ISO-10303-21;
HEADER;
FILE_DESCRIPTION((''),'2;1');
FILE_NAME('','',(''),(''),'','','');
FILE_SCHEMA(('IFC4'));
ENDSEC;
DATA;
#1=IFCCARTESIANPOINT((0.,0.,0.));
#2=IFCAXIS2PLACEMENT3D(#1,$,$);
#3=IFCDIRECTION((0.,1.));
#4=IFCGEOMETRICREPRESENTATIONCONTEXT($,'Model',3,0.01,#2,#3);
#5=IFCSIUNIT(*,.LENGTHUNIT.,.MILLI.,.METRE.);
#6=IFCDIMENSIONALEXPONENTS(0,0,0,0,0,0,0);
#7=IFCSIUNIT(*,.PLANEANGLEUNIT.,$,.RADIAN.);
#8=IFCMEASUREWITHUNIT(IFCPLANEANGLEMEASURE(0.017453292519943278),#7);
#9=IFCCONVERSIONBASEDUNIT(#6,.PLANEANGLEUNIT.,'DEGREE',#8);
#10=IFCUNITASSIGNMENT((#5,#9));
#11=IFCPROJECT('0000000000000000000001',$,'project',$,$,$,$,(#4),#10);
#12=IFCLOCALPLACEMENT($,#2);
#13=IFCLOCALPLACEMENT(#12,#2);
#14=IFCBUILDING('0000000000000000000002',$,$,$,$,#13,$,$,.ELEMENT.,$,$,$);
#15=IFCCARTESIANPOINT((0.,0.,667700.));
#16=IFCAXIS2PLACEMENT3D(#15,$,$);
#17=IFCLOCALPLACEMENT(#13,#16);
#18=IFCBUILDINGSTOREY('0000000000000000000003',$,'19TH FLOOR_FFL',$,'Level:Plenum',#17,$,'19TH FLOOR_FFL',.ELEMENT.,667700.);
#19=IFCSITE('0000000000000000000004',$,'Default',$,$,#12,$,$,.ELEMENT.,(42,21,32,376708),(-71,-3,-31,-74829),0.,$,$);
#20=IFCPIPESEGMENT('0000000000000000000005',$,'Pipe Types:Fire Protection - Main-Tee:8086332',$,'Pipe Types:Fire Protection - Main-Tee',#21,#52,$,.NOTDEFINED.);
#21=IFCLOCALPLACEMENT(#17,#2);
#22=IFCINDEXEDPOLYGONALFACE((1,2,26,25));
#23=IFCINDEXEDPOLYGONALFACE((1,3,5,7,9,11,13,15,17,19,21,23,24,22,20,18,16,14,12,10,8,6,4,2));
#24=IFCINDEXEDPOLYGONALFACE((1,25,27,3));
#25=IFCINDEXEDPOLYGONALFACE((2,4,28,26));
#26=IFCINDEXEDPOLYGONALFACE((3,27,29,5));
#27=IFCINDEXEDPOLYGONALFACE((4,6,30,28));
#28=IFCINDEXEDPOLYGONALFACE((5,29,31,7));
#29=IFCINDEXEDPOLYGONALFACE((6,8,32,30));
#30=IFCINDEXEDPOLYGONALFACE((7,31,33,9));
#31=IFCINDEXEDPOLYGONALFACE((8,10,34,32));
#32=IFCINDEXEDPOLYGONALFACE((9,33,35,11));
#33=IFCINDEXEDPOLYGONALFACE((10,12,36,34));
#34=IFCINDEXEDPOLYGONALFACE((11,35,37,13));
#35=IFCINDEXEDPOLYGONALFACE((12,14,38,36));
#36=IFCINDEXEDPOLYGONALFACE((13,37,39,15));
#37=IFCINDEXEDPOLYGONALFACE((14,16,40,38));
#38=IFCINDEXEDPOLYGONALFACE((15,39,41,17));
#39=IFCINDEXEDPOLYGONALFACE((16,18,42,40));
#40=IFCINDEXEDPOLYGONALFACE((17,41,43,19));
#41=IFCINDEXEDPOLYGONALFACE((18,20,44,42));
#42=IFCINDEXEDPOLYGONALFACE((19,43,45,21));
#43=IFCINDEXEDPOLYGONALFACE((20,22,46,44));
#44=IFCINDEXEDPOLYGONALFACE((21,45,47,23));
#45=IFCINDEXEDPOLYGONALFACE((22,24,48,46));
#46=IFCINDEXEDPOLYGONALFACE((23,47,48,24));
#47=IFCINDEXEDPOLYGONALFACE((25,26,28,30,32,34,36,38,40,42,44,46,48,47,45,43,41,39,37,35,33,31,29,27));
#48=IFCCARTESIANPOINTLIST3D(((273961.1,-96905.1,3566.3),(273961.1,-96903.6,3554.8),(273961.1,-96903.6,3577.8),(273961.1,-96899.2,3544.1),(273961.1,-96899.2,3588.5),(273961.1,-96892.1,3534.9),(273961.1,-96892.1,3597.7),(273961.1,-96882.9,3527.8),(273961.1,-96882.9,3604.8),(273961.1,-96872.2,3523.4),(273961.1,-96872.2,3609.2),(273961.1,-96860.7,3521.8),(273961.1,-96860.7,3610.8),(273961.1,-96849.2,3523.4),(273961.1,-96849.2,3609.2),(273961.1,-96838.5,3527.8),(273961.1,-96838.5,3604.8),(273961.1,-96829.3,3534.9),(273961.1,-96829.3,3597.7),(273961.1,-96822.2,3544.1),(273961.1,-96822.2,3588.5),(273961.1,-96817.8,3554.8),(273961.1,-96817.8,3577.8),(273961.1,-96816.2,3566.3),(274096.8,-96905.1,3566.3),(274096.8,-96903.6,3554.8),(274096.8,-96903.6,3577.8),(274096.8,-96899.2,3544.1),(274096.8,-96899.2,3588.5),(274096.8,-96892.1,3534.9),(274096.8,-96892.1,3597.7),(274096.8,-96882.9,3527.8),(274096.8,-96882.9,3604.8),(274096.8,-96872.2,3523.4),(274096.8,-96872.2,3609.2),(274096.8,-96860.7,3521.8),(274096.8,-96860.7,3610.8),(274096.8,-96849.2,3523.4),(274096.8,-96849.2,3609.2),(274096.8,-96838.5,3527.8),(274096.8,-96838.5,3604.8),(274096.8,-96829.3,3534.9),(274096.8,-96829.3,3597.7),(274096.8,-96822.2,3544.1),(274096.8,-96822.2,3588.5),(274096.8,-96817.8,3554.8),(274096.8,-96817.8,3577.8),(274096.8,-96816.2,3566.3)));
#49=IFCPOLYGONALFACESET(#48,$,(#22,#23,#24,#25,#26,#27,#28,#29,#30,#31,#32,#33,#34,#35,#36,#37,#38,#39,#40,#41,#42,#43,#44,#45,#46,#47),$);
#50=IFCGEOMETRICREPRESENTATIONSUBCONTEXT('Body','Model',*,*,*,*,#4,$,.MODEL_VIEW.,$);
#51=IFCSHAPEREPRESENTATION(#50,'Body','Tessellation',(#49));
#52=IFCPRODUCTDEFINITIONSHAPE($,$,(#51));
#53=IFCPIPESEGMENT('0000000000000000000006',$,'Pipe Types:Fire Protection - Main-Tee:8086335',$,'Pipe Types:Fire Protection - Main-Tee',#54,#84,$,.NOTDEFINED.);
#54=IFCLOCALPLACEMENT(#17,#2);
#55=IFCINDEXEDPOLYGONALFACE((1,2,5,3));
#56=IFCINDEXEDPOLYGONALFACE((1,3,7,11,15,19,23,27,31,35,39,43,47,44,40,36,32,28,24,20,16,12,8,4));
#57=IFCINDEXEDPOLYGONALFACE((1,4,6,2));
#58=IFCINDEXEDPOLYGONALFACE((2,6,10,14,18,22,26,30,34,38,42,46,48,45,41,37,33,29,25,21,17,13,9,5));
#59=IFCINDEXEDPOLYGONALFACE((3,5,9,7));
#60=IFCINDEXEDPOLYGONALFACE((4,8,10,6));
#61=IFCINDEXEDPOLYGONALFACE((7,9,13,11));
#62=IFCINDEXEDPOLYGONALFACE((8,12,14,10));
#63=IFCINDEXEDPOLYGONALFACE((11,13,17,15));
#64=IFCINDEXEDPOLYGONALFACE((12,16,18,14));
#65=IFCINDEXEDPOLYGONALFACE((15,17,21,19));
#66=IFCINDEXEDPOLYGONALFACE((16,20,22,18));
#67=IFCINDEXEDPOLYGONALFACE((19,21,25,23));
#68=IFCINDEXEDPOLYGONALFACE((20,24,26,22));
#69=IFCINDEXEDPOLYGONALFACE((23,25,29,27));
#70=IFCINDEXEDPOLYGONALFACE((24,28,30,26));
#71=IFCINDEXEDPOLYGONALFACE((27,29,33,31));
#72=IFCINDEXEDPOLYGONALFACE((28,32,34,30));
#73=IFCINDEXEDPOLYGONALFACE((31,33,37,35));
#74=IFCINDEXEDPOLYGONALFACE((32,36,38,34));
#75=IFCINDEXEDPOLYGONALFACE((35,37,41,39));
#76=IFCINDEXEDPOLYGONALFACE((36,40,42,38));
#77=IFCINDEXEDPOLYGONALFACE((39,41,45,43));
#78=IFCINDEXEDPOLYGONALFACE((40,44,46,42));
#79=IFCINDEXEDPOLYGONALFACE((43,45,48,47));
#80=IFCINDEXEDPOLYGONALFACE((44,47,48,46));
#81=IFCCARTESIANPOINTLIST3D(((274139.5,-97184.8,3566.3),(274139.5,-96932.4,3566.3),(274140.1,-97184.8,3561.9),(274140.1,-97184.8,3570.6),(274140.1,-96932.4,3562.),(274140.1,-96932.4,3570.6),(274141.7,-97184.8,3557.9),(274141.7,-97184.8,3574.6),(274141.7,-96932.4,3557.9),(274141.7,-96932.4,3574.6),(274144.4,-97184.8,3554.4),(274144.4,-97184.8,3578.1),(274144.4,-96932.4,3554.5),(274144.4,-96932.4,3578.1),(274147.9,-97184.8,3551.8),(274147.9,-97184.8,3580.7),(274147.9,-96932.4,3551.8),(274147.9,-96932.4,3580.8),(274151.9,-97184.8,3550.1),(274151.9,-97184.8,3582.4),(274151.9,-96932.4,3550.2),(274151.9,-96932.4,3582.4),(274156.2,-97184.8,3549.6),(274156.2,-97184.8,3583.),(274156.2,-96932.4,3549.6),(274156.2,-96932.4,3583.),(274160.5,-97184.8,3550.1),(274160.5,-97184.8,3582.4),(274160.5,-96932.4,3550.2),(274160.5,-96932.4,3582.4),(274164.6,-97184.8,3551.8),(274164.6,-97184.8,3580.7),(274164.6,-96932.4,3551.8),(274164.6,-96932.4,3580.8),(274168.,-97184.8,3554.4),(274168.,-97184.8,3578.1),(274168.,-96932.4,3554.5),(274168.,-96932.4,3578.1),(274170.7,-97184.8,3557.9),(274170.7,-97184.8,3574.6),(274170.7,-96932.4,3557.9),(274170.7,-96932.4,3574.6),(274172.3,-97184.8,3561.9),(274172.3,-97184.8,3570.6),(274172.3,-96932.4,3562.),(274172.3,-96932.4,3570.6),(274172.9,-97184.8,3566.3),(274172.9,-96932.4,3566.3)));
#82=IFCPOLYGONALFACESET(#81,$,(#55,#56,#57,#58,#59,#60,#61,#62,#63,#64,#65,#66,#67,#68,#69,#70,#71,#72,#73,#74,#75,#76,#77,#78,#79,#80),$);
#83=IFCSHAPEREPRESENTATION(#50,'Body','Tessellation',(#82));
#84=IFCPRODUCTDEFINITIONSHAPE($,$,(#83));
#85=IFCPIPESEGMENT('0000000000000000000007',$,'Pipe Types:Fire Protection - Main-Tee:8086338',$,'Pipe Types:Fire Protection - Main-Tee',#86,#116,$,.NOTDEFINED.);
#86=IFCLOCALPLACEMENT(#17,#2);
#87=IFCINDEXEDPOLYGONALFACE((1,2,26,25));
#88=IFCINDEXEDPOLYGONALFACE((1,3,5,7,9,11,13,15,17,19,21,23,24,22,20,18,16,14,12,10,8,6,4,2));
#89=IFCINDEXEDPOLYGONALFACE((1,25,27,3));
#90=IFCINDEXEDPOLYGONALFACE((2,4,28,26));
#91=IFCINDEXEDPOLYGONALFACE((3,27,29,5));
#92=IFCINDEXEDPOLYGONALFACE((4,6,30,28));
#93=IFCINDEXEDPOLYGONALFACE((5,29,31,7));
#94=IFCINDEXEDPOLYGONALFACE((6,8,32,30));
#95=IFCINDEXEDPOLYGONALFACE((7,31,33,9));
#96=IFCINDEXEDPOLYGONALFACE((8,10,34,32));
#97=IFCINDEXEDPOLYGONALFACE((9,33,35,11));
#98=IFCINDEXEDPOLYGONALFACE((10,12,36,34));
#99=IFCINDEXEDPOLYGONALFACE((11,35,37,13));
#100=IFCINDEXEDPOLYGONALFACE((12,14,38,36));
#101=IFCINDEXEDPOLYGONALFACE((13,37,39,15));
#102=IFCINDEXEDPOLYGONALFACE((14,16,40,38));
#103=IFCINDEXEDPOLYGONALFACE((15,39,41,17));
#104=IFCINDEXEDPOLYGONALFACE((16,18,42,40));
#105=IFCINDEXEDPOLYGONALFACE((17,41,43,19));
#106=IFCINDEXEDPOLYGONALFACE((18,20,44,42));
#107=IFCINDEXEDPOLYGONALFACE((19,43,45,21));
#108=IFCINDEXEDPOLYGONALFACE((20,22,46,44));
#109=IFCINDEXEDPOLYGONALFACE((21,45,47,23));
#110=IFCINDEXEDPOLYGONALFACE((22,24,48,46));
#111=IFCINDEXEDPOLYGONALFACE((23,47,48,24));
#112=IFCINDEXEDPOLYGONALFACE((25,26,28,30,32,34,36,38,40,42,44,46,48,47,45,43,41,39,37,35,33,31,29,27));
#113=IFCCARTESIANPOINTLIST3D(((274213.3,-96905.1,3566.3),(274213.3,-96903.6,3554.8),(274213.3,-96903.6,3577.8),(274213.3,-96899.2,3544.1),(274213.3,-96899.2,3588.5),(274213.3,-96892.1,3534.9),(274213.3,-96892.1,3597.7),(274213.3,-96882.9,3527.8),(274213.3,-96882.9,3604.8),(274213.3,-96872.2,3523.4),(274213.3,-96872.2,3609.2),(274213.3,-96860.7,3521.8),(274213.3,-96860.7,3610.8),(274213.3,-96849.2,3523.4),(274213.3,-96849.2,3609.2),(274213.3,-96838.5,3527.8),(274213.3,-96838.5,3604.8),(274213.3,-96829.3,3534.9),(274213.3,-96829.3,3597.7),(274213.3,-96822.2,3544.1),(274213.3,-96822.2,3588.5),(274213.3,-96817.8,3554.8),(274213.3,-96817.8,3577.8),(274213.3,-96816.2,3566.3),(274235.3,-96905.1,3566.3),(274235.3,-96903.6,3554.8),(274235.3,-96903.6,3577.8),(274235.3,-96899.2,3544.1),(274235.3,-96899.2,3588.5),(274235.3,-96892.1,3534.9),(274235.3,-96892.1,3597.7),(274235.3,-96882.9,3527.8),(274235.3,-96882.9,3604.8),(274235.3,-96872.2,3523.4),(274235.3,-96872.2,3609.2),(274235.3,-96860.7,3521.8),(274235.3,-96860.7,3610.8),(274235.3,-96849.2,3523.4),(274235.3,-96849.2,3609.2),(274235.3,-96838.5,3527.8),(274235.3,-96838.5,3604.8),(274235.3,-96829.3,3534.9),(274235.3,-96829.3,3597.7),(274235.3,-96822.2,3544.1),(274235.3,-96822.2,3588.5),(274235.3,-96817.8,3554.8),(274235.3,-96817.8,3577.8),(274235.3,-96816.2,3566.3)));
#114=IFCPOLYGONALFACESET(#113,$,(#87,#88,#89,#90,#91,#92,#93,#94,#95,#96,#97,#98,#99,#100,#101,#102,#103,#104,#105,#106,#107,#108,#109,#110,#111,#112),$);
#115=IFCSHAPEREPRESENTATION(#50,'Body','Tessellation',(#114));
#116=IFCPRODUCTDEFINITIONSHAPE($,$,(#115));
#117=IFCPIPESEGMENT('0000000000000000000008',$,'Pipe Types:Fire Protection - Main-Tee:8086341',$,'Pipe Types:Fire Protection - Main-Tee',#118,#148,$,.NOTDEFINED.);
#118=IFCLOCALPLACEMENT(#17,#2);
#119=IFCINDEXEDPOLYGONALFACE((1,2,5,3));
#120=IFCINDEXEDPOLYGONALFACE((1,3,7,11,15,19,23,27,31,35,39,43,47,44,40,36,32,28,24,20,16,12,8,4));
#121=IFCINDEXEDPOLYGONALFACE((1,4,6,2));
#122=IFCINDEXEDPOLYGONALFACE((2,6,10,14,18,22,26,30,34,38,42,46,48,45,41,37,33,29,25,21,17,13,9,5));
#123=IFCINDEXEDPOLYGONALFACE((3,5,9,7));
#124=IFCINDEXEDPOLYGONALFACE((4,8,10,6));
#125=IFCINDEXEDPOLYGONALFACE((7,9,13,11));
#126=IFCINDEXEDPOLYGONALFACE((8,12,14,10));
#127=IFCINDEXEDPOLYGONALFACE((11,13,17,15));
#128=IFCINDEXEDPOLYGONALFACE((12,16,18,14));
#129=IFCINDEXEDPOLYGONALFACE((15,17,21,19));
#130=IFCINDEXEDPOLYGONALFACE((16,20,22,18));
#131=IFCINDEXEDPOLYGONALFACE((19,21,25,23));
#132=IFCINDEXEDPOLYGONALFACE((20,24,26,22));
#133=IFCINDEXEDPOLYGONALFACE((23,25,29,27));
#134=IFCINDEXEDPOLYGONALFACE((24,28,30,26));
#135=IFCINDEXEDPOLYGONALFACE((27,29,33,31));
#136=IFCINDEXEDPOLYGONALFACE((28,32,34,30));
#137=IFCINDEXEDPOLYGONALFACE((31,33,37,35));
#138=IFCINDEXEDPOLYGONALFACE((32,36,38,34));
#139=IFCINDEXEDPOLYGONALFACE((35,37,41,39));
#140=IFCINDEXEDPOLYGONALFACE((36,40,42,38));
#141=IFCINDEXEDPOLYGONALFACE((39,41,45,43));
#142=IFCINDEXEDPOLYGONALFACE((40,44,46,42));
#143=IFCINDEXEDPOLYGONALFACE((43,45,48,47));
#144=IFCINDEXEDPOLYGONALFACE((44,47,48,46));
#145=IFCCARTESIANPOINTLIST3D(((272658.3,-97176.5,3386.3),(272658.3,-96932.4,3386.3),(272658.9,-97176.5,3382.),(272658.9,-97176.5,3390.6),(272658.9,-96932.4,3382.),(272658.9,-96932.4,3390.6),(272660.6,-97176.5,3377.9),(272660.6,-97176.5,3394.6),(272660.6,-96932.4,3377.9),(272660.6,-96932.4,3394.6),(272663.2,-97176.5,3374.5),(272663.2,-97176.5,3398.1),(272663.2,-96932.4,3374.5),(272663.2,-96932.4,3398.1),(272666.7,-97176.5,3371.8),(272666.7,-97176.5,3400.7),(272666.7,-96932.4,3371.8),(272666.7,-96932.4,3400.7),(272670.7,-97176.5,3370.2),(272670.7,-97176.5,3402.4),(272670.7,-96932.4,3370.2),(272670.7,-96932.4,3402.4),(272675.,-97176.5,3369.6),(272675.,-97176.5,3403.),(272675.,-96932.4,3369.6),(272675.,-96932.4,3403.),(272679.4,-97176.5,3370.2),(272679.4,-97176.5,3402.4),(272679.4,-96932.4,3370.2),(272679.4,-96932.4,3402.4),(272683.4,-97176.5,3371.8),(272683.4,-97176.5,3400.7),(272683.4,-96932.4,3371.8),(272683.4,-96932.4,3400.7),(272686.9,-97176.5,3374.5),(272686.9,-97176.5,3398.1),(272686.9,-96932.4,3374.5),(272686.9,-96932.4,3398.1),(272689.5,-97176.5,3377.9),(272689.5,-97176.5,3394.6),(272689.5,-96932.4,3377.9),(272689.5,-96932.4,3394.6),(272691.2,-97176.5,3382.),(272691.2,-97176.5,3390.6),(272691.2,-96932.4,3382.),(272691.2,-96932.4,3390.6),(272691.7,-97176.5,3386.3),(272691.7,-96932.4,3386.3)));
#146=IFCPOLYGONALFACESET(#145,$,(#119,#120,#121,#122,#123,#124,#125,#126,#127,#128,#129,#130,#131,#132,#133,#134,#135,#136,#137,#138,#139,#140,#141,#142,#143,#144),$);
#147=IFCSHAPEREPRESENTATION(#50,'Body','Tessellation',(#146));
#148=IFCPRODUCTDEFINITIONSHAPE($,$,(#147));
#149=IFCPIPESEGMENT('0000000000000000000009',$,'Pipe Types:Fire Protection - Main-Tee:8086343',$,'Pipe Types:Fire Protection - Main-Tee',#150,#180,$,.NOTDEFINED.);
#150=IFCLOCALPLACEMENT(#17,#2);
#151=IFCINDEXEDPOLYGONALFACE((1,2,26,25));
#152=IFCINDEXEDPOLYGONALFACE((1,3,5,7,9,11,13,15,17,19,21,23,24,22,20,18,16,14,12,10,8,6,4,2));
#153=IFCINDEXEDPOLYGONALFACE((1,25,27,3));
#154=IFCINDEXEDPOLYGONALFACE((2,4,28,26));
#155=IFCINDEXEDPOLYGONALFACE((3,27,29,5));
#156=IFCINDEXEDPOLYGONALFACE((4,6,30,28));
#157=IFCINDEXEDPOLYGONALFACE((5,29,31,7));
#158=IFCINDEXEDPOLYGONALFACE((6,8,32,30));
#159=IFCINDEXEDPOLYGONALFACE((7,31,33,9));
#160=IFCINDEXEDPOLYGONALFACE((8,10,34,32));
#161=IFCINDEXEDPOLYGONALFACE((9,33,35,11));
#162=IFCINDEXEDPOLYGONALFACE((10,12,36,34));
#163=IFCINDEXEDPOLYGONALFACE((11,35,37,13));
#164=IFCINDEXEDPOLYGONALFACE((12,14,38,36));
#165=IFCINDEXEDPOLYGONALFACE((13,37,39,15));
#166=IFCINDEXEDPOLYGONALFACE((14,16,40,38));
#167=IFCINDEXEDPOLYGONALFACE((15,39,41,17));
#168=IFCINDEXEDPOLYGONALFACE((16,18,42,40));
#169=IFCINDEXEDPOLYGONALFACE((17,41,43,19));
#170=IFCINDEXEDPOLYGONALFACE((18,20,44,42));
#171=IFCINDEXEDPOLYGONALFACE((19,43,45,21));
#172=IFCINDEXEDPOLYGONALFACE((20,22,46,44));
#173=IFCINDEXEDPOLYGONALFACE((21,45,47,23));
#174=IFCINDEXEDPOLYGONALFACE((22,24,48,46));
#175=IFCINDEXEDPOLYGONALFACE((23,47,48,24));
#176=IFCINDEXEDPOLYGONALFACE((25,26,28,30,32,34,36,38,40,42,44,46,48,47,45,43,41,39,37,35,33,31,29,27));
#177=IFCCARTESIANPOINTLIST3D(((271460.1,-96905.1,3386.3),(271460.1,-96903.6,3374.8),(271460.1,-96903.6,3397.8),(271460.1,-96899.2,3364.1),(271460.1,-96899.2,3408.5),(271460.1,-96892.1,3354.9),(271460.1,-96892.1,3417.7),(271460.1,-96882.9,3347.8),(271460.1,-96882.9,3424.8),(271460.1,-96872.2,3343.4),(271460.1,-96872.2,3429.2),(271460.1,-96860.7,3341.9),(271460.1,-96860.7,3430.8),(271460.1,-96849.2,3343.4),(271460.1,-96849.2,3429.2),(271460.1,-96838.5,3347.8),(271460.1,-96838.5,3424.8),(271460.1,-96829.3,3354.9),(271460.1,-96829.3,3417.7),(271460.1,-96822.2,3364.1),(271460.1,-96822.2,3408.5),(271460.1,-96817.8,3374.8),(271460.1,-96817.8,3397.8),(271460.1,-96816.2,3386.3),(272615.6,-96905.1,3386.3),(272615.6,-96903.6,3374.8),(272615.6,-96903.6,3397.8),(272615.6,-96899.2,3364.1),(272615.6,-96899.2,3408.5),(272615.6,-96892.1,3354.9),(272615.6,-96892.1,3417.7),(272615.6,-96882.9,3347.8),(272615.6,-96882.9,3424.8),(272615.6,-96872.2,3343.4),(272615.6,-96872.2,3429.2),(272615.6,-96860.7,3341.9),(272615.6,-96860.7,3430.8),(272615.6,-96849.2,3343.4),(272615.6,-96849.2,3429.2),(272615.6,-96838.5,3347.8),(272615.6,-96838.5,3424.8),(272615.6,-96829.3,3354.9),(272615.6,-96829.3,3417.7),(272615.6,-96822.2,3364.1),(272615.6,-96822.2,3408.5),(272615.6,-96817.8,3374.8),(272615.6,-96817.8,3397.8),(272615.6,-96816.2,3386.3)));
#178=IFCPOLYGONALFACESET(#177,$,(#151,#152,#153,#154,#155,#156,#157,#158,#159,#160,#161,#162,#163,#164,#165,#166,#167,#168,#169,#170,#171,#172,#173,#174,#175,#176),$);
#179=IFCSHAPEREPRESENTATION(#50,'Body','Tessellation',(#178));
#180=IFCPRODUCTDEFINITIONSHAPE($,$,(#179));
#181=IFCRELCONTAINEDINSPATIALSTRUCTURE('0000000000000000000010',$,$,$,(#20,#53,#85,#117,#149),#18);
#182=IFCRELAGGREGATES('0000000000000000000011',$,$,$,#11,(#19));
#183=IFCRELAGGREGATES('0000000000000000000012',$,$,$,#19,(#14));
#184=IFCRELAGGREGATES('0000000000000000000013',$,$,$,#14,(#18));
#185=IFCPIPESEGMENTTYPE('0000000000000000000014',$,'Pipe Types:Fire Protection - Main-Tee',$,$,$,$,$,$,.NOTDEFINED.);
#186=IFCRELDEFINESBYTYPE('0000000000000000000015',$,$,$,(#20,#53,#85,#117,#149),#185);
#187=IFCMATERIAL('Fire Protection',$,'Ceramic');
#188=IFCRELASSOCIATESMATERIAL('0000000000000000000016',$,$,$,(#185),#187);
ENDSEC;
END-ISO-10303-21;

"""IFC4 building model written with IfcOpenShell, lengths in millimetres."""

from ifc_helpers import new_model, entity, si_unit, converted_unit, direction, frame, origin, place, context, subcontext, project, spatial, arc, indexed_curve, outline, extrude, material, type_object, element, save


model = new_model("IFC4")

# Units and contexts
model_context = context("Model", 3, precision=0.01, world=origin(), true_north=direction((0.0, 1.0)))
body_context = subcontext(model_context, "Body", "Model", "MODEL_VIEW")
ifc_project = project(units=[si_unit("LENGTHUNIT", "METRE", prefix="MILLI"), converted_unit("PLANEANGLEUNIT", "DEGREE", entity("IfcPlaneAngleMeasure", 0.017453292519943278), si_unit("PLANEANGLEUNIT", "RADIAN"), dimensions=[0, 0, 0, 0, 0, 0, 0])], contexts=[model_context])

# Site, building, storey
site_placement = place(None, origin())
site = spatial("IfcSite", under=ifc_project, at=site_placement, Name="Default", CompositionType="ELEMENT", RefLatitude=(42, 21, 32, 376708), RefLongitude=(-71, -3, -31, -74829), RefElevation=0.0)
building_placement = place(site_placement, origin())
building = spatial("IfcBuilding", under=site, at=building_placement, CompositionType="ELEMENT")
storey_placement = place(building_placement, frame((0.0, 0.0, 667700.0)))
storey = spatial("IfcBuildingStorey", under=building, at=storey_placement, Name="19TH FLOOR_FFL", ObjectType="Level:Plenum", LongName="19TH FLOOR_FFL", CompositionType="ELEMENT", Elevation=667700.0)

# Pipe segments
ifc_material_1 = material(Name="Fire Protection", Category="Ceramic")
pipe_segment_type = type_object("IfcPipeSegmentType", Name="Pipe Types:Fire Protection - Main-Tee", PredefinedType="NOTDEFINED", material=ifc_material_1)
pipe_segment_1_placement = place(storey_placement, origin())
element("IfcPipeSegment", 1, at=pipe_segment_1_placement, inside=storey, type_object=pipe_segment_type, Name="Pipe Types:Fire Protection - Main-Tee:8086332", ObjectType="Pipe Types:Fire Protection - Main-Tee", PredefinedType="NOTDEFINED", context=body_context, shape_type="SweptSolid", body=[
    extrude(outline(indexed_curve([(44.4, 0.0), (31.4, 31.4), (0.0, 44.5), (-31.4, 31.4), (-44.4, 0.0), (-31.4, -31.4), (0.0, -44.4), (31.4, -31.4)], segments=[arc(1, 2, 3), arc(3, 4, 5), arc(5, 6, 7), arc(7, 8, 1)], self_intersect=False)), frame((273961.1, -96860.7, 3566.3), z_axis=(1.0, 0.0, 0.0), x_axis=(0.0, 1.0, 0.0)), (0.0, 0.0, 1.0), 135.7),
])
pipe_segment_2_placement = place(storey_placement, origin())
element("IfcPipeSegment", 2, at=pipe_segment_2_placement, inside=storey, type_object=pipe_segment_type, Name="Pipe Types:Fire Protection - Main-Tee:8086335", ObjectType="Pipe Types:Fire Protection - Main-Tee", PredefinedType="NOTDEFINED", context=body_context, shape_type="SweptSolid", body=[
    extrude(outline(indexed_curve([(16.7, 0.0), (11.8, 11.8), (0.0, 16.7), (-11.8, 11.8), (-16.7, 0.0), (-11.8, -11.8), (0.0, -16.7), (11.8, -11.8)], segments=[arc(1, 2, 3), arc(3, 4, 5), arc(5, 6, 7), arc(7, 8, 1)], self_intersect=False)), frame((274156.2, -97184.8, 3566.3), z_axis=(0.0, 1.0, 0.000145), x_axis=(-1.0, 0.0, 0.0)), (0.0, 0.0, 1.0), 252.4),
])
pipe_segment_3_placement = place(storey_placement, origin())
element("IfcPipeSegment", 3, at=pipe_segment_3_placement, inside=storey, type_object=pipe_segment_type, Name="Pipe Types:Fire Protection - Main-Tee:8086338", ObjectType="Pipe Types:Fire Protection - Main-Tee", PredefinedType="NOTDEFINED", context=body_context, shape_type="SweptSolid", body=[
    extrude(outline(indexed_curve([(44.4, 0.0), (31.4, 31.4), (0.0, 44.5), (-31.4, 31.4), (-44.4, 0.0), (-31.4, -31.4), (0.0, -44.4), (31.4, -31.4)], segments=[arc(1, 2, 3), arc(3, 4, 5), arc(5, 6, 7), arc(7, 8, 1)], self_intersect=False)), frame((274213.3, -96860.7, 3566.3), z_axis=(1.0, 0.0, 0.0), x_axis=(0.0, 1.0, 0.0)), (0.0, 0.0, 1.0), 22.0),
])
pipe_segment_4_placement = place(storey_placement, origin())
element("IfcPipeSegment", 4, at=pipe_segment_4_placement, inside=storey, type_object=pipe_segment_type, Name="Pipe Types:Fire Protection - Main-Tee:8086341", ObjectType="Pipe Types:Fire Protection - Main-Tee", PredefinedType="NOTDEFINED", context=body_context, shape_type="SweptSolid", body=[
    extrude(outline(indexed_curve([(16.7, 0.0), (11.8, 11.8), (0.0, 16.7), (-11.8, 11.8), (-16.7, 0.0), (-11.8, -11.8), (0.0, -16.7), (11.8, -11.8)], segments=[arc(1, 2, 3), arc(3, 4, 5), arc(5, 6, 7), arc(7, 8, 1)], self_intersect=False)), frame((272675.0, -97176.5, 3386.3), z_axis=(0.0, 1.0, 0.0), x_axis=(-1.0, 0.0, 0.0)), (0.0, 0.0, 1.0), 244.1),
])
pipe_segment_5_placement = place(storey_placement, origin())
element("IfcPipeSegment", 5, at=pipe_segment_5_placement, inside=storey, type_object=pipe_segment_type, Name="Pipe Types:Fire Protection - Main-Tee:8086343", ObjectType="Pipe Types:Fire Protection - Main-Tee", PredefinedType="NOTDEFINED", context=body_context, shape_type="SweptSolid", body=[
    extrude(outline(indexed_curve([(44.4, 0.0), (31.4, 31.4), (0.0, 44.5), (-31.4, 31.4), (-44.4, 0.0), (-31.4, -31.4), (0.0, -44.5), (31.4, -31.4)], segments=[arc(1, 2, 3), arc(3, 4, 5), arc(5, 6, 7), arc(7, 8, 1)], self_intersect=False)), frame((271460.1, -96860.7, 3386.3), z_axis=(1.0, 0.0, 0.0), x_axis=(0.0, 1.0, 0.0)), (0.0, 0.0, 1.0), 1155.5),
])

save(model, "model.ifc")
